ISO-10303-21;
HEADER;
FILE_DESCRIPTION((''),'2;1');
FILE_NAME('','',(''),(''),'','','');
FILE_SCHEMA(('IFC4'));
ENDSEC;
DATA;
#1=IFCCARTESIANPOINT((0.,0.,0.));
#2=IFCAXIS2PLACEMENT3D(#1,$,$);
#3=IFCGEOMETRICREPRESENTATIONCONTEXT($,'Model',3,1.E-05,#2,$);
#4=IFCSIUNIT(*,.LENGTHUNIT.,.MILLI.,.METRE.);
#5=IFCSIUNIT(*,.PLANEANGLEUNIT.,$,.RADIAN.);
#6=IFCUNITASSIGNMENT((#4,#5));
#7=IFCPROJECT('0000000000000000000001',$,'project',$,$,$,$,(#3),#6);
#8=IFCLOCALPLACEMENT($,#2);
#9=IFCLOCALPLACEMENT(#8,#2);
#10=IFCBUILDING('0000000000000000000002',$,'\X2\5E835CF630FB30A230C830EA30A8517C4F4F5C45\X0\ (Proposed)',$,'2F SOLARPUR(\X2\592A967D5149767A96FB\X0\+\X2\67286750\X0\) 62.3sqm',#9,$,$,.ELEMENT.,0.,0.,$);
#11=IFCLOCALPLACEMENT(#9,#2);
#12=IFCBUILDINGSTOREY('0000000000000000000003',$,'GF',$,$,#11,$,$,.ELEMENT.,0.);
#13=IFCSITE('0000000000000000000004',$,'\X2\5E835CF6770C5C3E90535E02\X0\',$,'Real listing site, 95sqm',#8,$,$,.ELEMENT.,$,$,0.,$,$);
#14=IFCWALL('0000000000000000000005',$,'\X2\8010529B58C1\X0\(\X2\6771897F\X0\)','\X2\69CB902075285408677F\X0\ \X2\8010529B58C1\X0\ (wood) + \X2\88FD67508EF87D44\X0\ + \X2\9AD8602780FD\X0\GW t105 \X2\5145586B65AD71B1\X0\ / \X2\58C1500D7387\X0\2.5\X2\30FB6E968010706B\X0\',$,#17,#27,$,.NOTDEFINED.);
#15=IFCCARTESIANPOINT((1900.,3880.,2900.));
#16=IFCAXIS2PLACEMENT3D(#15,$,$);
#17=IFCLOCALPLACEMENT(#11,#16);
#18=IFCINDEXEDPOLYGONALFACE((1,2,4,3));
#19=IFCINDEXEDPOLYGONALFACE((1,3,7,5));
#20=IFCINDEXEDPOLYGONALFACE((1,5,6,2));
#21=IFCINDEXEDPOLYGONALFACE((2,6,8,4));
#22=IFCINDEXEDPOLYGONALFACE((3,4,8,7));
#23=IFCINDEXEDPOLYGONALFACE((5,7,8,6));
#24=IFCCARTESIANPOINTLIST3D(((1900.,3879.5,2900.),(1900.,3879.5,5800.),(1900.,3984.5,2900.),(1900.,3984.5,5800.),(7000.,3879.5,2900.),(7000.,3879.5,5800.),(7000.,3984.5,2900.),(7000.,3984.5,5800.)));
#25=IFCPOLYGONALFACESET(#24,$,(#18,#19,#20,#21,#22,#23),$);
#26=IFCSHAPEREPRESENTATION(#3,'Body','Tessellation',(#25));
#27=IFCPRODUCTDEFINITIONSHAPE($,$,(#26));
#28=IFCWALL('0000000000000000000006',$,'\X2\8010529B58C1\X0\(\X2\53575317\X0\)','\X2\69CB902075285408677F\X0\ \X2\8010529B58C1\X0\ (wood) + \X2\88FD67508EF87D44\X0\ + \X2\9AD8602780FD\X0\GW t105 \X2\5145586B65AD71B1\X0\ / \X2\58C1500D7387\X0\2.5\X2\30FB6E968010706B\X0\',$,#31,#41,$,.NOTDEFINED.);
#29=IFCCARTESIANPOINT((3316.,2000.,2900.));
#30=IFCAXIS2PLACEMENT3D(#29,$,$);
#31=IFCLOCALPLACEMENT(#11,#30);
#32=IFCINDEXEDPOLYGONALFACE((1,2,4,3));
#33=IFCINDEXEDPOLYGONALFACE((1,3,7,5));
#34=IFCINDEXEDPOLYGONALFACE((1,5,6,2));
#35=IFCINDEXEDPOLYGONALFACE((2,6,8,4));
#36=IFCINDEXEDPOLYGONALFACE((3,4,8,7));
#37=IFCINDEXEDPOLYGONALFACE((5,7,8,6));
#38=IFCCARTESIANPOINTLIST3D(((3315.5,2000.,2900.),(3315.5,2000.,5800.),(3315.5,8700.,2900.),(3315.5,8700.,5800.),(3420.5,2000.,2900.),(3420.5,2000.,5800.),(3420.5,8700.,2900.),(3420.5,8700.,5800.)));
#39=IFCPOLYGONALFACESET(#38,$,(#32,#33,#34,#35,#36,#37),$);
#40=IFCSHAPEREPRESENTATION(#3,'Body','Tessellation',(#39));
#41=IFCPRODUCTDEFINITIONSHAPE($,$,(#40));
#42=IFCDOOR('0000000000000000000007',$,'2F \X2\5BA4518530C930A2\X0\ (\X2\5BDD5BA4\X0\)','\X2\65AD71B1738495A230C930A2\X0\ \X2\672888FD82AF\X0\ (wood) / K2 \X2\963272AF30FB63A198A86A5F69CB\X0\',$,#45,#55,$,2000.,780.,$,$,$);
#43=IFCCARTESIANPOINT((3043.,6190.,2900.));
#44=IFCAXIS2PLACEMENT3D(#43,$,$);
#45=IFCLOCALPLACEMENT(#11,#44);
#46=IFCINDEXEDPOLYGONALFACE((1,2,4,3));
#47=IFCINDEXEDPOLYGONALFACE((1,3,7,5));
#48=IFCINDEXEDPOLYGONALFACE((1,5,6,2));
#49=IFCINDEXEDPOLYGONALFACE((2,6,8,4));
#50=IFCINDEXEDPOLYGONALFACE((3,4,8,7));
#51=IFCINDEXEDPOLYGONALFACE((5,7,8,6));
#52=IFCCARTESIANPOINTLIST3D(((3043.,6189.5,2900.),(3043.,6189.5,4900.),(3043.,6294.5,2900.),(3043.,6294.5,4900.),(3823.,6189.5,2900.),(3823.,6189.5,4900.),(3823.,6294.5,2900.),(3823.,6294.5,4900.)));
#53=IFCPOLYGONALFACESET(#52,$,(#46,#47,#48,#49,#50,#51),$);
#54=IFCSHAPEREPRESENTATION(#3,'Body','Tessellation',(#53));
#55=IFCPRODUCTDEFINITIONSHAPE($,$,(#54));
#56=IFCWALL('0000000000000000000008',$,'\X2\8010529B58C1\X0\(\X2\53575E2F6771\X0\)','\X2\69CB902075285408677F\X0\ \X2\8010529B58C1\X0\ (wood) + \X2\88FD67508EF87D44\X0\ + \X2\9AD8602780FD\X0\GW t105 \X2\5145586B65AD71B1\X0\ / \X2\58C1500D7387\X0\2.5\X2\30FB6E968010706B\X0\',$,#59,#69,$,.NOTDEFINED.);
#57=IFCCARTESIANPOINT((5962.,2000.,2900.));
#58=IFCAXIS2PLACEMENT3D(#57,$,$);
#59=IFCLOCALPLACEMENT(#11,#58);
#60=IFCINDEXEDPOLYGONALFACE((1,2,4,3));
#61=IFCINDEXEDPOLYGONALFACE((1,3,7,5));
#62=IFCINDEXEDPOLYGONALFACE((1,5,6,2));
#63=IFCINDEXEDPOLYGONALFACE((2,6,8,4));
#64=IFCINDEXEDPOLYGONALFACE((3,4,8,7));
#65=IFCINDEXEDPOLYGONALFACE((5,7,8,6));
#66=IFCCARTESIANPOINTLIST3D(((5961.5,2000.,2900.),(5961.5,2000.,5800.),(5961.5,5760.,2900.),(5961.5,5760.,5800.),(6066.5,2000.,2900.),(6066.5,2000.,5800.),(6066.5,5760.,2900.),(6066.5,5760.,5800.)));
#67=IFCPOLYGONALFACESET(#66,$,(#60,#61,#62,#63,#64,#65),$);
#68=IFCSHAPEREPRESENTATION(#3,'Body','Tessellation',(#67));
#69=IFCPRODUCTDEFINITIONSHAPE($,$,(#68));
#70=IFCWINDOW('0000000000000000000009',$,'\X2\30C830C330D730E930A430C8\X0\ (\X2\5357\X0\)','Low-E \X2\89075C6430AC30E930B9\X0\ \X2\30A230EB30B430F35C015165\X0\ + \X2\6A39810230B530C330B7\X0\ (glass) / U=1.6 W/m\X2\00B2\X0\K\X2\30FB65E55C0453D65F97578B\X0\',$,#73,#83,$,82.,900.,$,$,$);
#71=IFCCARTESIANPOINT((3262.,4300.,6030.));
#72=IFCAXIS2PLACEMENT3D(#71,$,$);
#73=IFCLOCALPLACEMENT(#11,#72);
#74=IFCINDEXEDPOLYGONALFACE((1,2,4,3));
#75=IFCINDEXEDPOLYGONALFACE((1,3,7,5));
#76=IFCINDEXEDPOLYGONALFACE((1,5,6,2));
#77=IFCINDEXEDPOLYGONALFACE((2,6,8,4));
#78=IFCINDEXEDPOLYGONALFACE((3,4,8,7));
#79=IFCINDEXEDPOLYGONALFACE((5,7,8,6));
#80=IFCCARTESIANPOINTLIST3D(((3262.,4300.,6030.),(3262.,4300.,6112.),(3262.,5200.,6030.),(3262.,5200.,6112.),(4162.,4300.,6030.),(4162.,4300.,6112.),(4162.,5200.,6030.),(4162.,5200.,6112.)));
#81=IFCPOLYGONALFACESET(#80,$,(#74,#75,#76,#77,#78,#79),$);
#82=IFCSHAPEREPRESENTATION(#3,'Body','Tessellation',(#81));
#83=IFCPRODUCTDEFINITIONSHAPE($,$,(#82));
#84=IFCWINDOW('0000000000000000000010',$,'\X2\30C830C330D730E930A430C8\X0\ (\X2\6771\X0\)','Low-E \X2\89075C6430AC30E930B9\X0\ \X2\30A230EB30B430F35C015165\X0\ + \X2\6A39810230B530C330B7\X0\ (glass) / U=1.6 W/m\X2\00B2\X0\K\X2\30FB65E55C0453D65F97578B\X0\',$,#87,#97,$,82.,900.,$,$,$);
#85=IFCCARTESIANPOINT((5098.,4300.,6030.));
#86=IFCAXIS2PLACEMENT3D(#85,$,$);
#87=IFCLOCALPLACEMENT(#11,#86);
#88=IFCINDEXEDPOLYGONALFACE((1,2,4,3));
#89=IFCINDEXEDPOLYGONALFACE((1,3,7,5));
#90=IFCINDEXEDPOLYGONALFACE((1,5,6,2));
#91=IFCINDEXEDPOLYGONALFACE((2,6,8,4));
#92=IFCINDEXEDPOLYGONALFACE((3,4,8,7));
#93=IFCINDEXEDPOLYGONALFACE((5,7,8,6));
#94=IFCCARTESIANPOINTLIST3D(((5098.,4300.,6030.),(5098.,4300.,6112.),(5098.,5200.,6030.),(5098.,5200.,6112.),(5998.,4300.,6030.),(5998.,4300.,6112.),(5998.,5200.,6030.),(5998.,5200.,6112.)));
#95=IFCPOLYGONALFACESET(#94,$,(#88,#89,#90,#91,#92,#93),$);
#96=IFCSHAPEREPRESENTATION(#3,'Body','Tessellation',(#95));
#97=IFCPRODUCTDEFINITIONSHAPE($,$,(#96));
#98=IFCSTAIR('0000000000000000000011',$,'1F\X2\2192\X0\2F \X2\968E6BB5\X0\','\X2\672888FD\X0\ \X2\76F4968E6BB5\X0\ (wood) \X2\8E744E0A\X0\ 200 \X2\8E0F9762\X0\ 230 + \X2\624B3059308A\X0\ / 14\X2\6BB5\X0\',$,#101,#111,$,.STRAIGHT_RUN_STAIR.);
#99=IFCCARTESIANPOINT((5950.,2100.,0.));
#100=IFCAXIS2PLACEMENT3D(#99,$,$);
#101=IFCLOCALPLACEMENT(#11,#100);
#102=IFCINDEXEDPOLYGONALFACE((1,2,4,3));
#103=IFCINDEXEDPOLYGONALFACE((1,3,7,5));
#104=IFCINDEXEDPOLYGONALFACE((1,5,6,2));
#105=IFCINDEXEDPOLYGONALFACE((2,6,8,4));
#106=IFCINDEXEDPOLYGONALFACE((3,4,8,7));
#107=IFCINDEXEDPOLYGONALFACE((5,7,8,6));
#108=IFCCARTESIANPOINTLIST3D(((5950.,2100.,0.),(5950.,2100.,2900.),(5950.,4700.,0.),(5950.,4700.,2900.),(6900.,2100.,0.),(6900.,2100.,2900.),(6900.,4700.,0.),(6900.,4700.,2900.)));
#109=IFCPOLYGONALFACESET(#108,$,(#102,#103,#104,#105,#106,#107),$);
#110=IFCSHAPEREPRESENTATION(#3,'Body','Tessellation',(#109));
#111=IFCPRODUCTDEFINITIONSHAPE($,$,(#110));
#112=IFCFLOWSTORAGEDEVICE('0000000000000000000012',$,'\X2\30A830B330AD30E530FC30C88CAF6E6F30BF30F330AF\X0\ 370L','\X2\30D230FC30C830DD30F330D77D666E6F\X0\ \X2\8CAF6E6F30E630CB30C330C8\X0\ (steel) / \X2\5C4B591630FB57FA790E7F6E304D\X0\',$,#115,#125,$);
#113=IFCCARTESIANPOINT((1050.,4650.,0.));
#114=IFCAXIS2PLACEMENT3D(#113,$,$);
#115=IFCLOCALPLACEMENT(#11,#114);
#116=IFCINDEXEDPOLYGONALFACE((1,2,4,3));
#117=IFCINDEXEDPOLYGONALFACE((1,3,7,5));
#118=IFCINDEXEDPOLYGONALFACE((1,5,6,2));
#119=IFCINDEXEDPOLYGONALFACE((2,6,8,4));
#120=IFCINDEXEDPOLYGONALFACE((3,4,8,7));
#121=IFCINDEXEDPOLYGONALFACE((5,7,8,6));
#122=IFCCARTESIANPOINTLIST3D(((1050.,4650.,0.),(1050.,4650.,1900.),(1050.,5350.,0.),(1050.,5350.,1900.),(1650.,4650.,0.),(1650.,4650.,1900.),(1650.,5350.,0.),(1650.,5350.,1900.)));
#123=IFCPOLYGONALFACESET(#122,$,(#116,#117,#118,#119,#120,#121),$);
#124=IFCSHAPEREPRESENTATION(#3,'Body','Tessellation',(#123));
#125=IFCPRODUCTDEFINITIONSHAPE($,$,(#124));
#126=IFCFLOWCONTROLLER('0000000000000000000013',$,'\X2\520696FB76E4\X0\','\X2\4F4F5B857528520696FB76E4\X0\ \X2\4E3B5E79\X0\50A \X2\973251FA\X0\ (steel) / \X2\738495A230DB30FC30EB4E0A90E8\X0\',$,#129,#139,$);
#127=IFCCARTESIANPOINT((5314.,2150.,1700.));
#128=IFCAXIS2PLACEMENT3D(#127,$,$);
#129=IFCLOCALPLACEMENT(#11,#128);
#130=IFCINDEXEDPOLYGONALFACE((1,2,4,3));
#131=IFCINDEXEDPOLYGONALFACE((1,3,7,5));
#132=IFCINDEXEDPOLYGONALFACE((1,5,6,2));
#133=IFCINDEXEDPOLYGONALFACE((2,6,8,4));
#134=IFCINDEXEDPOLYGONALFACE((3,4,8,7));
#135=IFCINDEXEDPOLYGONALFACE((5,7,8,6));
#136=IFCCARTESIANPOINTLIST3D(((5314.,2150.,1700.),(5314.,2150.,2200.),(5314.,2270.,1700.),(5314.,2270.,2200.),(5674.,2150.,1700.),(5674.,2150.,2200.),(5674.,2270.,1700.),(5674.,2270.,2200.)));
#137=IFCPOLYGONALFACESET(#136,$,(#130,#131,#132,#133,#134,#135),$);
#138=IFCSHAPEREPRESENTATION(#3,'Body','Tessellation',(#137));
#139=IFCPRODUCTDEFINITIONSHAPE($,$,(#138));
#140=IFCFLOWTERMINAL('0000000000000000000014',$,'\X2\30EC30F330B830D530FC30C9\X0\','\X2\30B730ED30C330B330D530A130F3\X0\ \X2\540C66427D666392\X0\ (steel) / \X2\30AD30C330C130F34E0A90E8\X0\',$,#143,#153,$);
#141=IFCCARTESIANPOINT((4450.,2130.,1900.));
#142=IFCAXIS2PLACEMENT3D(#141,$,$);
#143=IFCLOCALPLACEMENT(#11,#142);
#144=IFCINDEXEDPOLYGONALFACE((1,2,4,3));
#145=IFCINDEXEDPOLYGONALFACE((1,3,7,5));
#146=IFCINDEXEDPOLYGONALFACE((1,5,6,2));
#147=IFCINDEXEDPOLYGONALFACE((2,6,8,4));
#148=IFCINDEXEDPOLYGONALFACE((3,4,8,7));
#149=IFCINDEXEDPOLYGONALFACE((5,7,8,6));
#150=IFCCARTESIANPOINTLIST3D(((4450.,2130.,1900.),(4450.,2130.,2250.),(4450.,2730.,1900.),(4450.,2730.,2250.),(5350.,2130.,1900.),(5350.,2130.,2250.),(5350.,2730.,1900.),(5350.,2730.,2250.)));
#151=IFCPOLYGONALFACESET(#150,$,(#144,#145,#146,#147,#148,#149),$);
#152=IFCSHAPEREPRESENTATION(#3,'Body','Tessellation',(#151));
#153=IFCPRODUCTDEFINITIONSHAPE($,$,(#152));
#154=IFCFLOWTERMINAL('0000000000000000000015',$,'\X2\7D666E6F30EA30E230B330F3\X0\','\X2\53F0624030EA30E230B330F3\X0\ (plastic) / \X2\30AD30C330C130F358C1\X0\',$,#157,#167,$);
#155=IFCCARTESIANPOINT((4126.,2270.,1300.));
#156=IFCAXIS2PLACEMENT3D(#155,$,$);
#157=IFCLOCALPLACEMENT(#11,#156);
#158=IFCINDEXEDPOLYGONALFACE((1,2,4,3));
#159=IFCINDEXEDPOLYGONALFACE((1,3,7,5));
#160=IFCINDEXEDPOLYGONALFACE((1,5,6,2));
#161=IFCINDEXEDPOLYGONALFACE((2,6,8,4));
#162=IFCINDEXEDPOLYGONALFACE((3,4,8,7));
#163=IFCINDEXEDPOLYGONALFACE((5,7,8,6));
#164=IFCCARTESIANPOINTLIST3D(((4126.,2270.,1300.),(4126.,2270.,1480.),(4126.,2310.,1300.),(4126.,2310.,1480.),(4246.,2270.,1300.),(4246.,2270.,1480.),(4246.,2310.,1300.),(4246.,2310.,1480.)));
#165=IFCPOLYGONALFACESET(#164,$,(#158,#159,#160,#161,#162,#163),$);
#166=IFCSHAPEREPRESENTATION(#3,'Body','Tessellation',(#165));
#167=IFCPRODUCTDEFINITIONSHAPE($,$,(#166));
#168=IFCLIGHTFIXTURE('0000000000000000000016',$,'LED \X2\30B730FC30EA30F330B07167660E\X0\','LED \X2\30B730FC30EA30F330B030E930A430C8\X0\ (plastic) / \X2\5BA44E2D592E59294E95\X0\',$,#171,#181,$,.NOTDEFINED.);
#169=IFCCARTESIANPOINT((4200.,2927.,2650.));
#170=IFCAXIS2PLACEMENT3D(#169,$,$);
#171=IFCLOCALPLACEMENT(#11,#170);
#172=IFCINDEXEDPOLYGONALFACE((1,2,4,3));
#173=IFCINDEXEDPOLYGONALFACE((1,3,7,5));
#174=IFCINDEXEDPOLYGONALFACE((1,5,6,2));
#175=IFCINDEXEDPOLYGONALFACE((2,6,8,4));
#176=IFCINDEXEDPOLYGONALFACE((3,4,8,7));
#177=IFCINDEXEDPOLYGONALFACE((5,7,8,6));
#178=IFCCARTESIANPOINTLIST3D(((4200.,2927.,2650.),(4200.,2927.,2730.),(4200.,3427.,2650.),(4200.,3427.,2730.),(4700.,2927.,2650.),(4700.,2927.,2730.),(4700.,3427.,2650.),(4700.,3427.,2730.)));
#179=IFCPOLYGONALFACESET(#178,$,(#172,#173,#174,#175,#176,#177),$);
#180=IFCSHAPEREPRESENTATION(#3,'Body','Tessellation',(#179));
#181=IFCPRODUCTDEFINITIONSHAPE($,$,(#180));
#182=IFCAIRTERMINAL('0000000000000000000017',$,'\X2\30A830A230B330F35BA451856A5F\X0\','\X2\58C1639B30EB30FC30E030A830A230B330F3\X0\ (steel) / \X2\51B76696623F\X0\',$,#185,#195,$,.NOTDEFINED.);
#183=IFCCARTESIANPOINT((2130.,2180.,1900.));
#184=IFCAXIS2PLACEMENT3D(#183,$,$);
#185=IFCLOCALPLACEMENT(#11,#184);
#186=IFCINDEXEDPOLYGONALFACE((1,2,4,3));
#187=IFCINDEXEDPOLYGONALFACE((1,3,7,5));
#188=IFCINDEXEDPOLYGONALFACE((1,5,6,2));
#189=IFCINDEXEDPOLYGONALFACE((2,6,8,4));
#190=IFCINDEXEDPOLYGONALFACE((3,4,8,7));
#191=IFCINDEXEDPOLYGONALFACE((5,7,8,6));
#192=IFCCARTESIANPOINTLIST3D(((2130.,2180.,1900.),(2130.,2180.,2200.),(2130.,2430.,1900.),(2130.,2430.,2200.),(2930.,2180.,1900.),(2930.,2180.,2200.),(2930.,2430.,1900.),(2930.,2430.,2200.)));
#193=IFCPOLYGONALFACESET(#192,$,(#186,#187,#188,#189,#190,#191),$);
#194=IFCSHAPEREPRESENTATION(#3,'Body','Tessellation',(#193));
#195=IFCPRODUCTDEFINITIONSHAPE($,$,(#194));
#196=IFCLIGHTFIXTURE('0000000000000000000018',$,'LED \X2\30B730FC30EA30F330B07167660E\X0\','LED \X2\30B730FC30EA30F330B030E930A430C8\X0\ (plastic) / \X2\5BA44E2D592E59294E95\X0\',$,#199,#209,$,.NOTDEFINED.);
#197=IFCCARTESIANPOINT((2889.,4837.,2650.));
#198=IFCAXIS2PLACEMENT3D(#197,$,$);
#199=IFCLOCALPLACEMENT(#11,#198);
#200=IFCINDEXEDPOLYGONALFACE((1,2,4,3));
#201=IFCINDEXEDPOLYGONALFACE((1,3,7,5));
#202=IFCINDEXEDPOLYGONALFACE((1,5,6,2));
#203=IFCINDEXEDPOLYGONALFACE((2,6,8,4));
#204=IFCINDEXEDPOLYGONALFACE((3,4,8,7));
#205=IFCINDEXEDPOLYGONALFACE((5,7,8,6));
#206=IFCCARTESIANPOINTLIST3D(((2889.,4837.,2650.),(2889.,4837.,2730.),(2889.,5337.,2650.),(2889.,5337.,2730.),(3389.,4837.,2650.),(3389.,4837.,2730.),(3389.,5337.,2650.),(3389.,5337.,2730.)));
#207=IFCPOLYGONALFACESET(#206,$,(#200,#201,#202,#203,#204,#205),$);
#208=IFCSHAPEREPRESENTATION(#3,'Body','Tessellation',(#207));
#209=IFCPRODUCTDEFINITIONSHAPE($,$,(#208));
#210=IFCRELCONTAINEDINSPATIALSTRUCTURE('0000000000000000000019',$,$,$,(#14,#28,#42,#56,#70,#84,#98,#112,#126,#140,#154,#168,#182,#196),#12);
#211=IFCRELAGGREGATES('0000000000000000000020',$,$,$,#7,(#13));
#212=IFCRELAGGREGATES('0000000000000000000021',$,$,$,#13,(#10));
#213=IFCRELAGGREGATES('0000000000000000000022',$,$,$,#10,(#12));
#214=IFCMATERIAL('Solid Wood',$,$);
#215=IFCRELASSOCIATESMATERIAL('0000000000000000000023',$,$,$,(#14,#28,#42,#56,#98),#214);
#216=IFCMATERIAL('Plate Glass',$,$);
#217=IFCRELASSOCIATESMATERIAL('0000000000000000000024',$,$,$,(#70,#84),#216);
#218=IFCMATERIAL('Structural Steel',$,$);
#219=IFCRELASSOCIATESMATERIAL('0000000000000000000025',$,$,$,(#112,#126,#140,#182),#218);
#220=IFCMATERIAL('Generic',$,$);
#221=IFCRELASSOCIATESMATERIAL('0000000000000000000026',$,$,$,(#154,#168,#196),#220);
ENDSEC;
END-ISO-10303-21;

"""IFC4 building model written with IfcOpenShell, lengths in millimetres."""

from ifc_helpers import new_model, si_unit, frame, frame_2d, origin, place, context, project, spatial, rectangle, extrude, material, element, fill, save


model = new_model("IFC4")

# Units and contexts
model_context = context("Model", 3, precision=1e-05, world=origin())
ifc_project = project(units=[si_unit("LENGTHUNIT", "METRE", prefix="MILLI"), si_unit("PLANEANGLEUNIT", "RADIAN")], contexts=[model_context])

# Site, building, storey
site_placement = place(None, origin())
site = spatial("IfcSite", under=ifc_project, at=site_placement, Name="広島県尾道市", ObjectType="Real listing site, 95sqm", CompositionType="ELEMENT", RefElevation=0.0)
building_placement = place(site_placement, origin())
building = spatial("IfcBuilding", under=site, at=building_placement, Name="広島・アトリエ兼住居 (Proposed)", ObjectType="2F SOLARPUR(太陽光発電+木材) 62.3sqm", CompositionType="ELEMENT", ElevationOfRefHeight=0.0, ElevationOfTerrain=0.0)
storey_placement = place(building_placement, origin())
storey = spatial("IfcBuildingStorey", under=building, at=storey_placement, Name="GF", CompositionType="ELEMENT", Elevation=0.0)

# Shared definitions
ifc_material_1 = material(Name="Solid Wood")

# Wall
wall_1_placement = place(storey_placement, frame((1900.0, 3880.0, 2900.0)))
element("IfcWall", 1, at=wall_1_placement, inside=storey, material=ifc_material_1, Name="耐力壁(東西)", Description="構造用合板 耐力壁 (wood) + 製材軸組 + 高性能GW t105 充填断熱 / 壁倍率2.5・準耐火", PredefinedType="NOTDEFINED", context=model_context, shape_type="SweptSolid", body=[
    extrude(rectangle(XDim=5100.0, YDim=105.0, at=frame_2d((2550.0, 52.0))), frame((1900.0, 3880.0, 2900.0)), (0.0, 0.0, 1.0), 2900.0),
])

# Wall, opening, door
wall_2_placement = place(storey_placement, frame((3316.0, 2000.0, 2900.0)))
wall_2 = element("IfcWall", 2, at=wall_2_placement, inside=storey, material=ifc_material_1, Name="耐力壁(南北)", Description="構造用合板 耐力壁 (wood) + 製材軸組 + 高性能GW t105 充填断熱 / 壁倍率2.5・準耐火", PredefinedType="NOTDEFINED", context=model_context, shape_type="SweptSolid", body=[
    extrude(rectangle(XDim=105.0, YDim=6700.0, at=frame_2d((52.0, 3350.0))), frame((3316.0, 2000.0, 2900.0)), (0.0, 0.0, 1.0), 2900.0),
])
opening_placement = place(storey_placement, frame((3043.0, 6190.0, 2900.0)))
opening = element("IfcOpeningElement", 3, at=opening_placement, cuts=wall_2, PredefinedType="NOTDEFINED", context=model_context, shape_type="SweptSolid", body=[
    extrude(rectangle(XDim=780.0, YDim=105.0, at=frame_2d((390.0, 52.0))), frame((3043.0, 6190.0, 2900.0)), (0.0, 0.0, 1.0), 2000.0),
])
door_placement = place(storey_placement, frame((3043.0, 6190.0, 2900.0)))
door = element("IfcDoor", 4, at=door_placement, inside=storey, material=ifc_material_1, Name="2F 室内ドア (寝室)", Description="断熱玄関ドア 木製芯 (wood) / K2 防犯・採風機構", OverallHeight=2000.0, OverallWidth=780.0, context=model_context, shape_type="SweptSolid", body=[
    extrude(rectangle(XDim=780.0, YDim=105.0, at=frame_2d((390.0, 52.0))), frame((3043.0, 6190.0, 2900.0)), (0.0, 0.0, 1.0), 2000.0),
])
fill(opening, door)

# Wall
wall_3_placement = place(storey_placement, frame((5962.0, 2000.0, 2900.0)))
element("IfcWall", 5, at=wall_3_placement, inside=storey, material=ifc_material_1, Name="耐力壁(南帯東)", Description="構造用合板 耐力壁 (wood) + 製材軸組 + 高性能GW t105 充填断熱 / 壁倍率2.5・準耐火", PredefinedType="NOTDEFINED", context=model_context, shape_type="SweptSolid", body=[
    extrude(rectangle(XDim=105.0, YDim=3760.0, at=frame_2d((52.0, 1880.0))), frame((5962.0, 2000.0, 2900.0)), (0.0, 0.0, 1.0), 2900.0),
])

# Windows
ifc_material_2 = material(Name="Plate Glass")
window_1_placement = place(storey_placement, frame((3262.0, 4300.0, 6030.0)))
element("IfcWindow", 6, at=window_1_placement, inside=storey, material=ifc_material_2, Name="トップライト (南)", Description="Low-E 複層ガラス アルゴン封入 + 樹脂サッシ (glass) / U=1.6 W/m²K・日射取得型", OverallHeight=82.0, OverallWidth=900.0, context=model_context, shape_type="SweptSolid", body=[
    extrude(rectangle(XDim=900.0, YDim=900.0, at=frame_2d((450.0, 450.0))), frame((3262.0, 4300.0, 6030.0)), (0.0, 0.0, 1.0), 82.0),
])
window_2_placement = place(storey_placement, frame((5098.0, 4300.0, 6030.0)))
element("IfcWindow", 7, at=window_2_placement, inside=storey, material=ifc_material_2, Name="トップライト (東)", Description="Low-E 複層ガラス アルゴン封入 + 樹脂サッシ (glass) / U=1.6 W/m²K・日射取得型", OverallHeight=82.0, OverallWidth=900.0, context=model_context, shape_type="SweptSolid", body=[
    extrude(rectangle(XDim=900.0, YDim=900.0, at=frame_2d((450.0, 450.0))), frame((5098.0, 4300.0, 6030.0)), (0.0, 0.0, 1.0), 82.0),
])

# Stair
stair_placement = place(storey_placement, frame((5950.0, 2100.0, 0.0)))
element("IfcStair", 8, at=stair_placement, inside=storey, material=ifc_material_1, Name="1F→2F 階段", Description="木製 直階段 (wood) 蹴上 200 踏面 230 + 手すり / 14段", PredefinedType="STRAIGHT_RUN_STAIR", context=model_context, shape_type="SweptSolid", body=[
    extrude(rectangle(XDim=950.0, YDim=2600.0, at=frame_2d((475.0, 1300.0))), frame((5950.0, 2100.0, 0.0)), (0.0, 0.0, 1.0), 2900.0),
])

# Flow storage device
ifc_material_3 = material(Name="Structural Steel")
flow_storage_device_placement = place(storey_placement, frame((1050.0, 4650.0, 0.0)))
element("IfcFlowStorageDevice", 9, at=flow_storage_device_placement, inside=storey, material=ifc_material_3, Name="エコキュート貯湯タンク 370L", Description="ヒートポンプ給湯 貯湯ユニット (steel) / 屋外・基礎置き", context=model_context, shape_type="SweptSolid", body=[
    extrude(rectangle(XDim=600.0, YDim=700.0, at=frame_2d((300.0, 350.0))), frame((1050.0, 4650.0, 0.0)), (0.0, 0.0, 1.0), 1900.0),
])

# Flow controller
flow_controller_placement = place(storey_placement, frame((5314.0, 2150.0, 1700.0)))
element("IfcFlowController", 10, at=flow_controller_placement, inside=storey, material=ifc_material_3, Name="分電盤", Description="住宅用分電盤 主幹50A 露出 (steel) / 玄関ホール上部", context=model_context, shape_type="SweptSolid", body=[
    extrude(rectangle(XDim=360.0, YDim=120.0, at=frame_2d((180.0, 60.0))), frame((5314.0, 2150.0, 1700.0)), (0.0, 0.0, 1.0), 500.0),
])

# Flow terminals
flow_terminal_1_placement = place(storey_placement, frame((4450.0, 2130.0, 1900.0)))
element("IfcFlowTerminal", 11, at=flow_terminal_1_placement, inside=storey, material=ifc_material_3, Name="レンジフード", Description="シロッコファン 同時給排 (steel) / キッチン上部", context=model_context, shape_type="SweptSolid", body=[
    extrude(rectangle(XDim=900.0, YDim=600.0, at=frame_2d((450.0, 300.0))), frame((4450.0, 2130.0, 1900.0)), (0.0, 0.0, 1.0), 350.0),
])
ifc_material_4 = material(Name="Generic")
flow_terminal_2_placement = place(storey_placement, frame((4126.0, 2270.0, 1300.0)))
element("IfcFlowTerminal", 12, at=flow_terminal_2_placement, inside=storey, material=ifc_material_4, Name="給湯リモコン", Description="台所リモコン (plastic) / キッチン壁", context=model_context, shape_type="SweptSolid", body=[
    extrude(rectangle(XDim=120.0, YDim=40.0, at=frame_2d((60.0, 20.0))), frame((4126.0, 2270.0, 1300.0)), (0.0, 0.0, 1.0), 180.0),
])

# Light fixture
light_fixture_1_placement = place(storey_placement, frame((4200.0, 2927.0, 2650.0)))
element("IfcLightFixture", 13, at=light_fixture_1_placement, inside=storey, material=ifc_material_4, Name="LED シーリング照明", Description="LED シーリングライト (plastic) / 室中央天井", PredefinedType="NOTDEFINED", context=model_context, shape_type="SweptSolid", body=[
    extrude(rectangle(XDim=500.0, YDim=500.0, at=frame_2d((250.0, 250.0))), frame((4200.0, 2927.0, 2650.0)), (0.0, 0.0, 1.0), 80.0),
])

# Air terminal
air_terminal_1_placement = place(storey_placement, frame((2130.0, 2180.0, 1900.0)))
element("IfcAirTerminal", 14, at=air_terminal_1_placement, inside=storey, material=ifc_material_3, Name="エアコン室内機", Description="壁掛ルームエアコン (steel) / 冷暖房", PredefinedType="NOTDEFINED", context=model_context, shape_type="SweptSolid", body=[
    extrude(rectangle(XDim=800.0, YDim=250.0, at=frame_2d((400.0, 125.0))), frame((2130.0, 2180.0, 1900.0)), (0.0, 0.0, 1.0), 300.0),
])

# Light fixture
light_fixture_2_placement = place(storey_placement, frame((2889.0, 4837.0, 2650.0)))
element("IfcLightFixture", 15, at=light_fixture_2_placement, inside=storey, material=ifc_material_4, Name="LED シーリング照明", Description="LED シーリングライト (plastic) / 室中央天井", PredefinedType="NOTDEFINED", context=model_context, shape_type="SweptSolid", body=[
    extrude(rectangle(XDim=500.0, YDim=500.0, at=frame_2d((250.0, 250.0))), frame((2889.0, 4837.0, 2650.0)), (0.0, 0.0, 1.0), 80.0),
])

save(model, "model.ifc")
